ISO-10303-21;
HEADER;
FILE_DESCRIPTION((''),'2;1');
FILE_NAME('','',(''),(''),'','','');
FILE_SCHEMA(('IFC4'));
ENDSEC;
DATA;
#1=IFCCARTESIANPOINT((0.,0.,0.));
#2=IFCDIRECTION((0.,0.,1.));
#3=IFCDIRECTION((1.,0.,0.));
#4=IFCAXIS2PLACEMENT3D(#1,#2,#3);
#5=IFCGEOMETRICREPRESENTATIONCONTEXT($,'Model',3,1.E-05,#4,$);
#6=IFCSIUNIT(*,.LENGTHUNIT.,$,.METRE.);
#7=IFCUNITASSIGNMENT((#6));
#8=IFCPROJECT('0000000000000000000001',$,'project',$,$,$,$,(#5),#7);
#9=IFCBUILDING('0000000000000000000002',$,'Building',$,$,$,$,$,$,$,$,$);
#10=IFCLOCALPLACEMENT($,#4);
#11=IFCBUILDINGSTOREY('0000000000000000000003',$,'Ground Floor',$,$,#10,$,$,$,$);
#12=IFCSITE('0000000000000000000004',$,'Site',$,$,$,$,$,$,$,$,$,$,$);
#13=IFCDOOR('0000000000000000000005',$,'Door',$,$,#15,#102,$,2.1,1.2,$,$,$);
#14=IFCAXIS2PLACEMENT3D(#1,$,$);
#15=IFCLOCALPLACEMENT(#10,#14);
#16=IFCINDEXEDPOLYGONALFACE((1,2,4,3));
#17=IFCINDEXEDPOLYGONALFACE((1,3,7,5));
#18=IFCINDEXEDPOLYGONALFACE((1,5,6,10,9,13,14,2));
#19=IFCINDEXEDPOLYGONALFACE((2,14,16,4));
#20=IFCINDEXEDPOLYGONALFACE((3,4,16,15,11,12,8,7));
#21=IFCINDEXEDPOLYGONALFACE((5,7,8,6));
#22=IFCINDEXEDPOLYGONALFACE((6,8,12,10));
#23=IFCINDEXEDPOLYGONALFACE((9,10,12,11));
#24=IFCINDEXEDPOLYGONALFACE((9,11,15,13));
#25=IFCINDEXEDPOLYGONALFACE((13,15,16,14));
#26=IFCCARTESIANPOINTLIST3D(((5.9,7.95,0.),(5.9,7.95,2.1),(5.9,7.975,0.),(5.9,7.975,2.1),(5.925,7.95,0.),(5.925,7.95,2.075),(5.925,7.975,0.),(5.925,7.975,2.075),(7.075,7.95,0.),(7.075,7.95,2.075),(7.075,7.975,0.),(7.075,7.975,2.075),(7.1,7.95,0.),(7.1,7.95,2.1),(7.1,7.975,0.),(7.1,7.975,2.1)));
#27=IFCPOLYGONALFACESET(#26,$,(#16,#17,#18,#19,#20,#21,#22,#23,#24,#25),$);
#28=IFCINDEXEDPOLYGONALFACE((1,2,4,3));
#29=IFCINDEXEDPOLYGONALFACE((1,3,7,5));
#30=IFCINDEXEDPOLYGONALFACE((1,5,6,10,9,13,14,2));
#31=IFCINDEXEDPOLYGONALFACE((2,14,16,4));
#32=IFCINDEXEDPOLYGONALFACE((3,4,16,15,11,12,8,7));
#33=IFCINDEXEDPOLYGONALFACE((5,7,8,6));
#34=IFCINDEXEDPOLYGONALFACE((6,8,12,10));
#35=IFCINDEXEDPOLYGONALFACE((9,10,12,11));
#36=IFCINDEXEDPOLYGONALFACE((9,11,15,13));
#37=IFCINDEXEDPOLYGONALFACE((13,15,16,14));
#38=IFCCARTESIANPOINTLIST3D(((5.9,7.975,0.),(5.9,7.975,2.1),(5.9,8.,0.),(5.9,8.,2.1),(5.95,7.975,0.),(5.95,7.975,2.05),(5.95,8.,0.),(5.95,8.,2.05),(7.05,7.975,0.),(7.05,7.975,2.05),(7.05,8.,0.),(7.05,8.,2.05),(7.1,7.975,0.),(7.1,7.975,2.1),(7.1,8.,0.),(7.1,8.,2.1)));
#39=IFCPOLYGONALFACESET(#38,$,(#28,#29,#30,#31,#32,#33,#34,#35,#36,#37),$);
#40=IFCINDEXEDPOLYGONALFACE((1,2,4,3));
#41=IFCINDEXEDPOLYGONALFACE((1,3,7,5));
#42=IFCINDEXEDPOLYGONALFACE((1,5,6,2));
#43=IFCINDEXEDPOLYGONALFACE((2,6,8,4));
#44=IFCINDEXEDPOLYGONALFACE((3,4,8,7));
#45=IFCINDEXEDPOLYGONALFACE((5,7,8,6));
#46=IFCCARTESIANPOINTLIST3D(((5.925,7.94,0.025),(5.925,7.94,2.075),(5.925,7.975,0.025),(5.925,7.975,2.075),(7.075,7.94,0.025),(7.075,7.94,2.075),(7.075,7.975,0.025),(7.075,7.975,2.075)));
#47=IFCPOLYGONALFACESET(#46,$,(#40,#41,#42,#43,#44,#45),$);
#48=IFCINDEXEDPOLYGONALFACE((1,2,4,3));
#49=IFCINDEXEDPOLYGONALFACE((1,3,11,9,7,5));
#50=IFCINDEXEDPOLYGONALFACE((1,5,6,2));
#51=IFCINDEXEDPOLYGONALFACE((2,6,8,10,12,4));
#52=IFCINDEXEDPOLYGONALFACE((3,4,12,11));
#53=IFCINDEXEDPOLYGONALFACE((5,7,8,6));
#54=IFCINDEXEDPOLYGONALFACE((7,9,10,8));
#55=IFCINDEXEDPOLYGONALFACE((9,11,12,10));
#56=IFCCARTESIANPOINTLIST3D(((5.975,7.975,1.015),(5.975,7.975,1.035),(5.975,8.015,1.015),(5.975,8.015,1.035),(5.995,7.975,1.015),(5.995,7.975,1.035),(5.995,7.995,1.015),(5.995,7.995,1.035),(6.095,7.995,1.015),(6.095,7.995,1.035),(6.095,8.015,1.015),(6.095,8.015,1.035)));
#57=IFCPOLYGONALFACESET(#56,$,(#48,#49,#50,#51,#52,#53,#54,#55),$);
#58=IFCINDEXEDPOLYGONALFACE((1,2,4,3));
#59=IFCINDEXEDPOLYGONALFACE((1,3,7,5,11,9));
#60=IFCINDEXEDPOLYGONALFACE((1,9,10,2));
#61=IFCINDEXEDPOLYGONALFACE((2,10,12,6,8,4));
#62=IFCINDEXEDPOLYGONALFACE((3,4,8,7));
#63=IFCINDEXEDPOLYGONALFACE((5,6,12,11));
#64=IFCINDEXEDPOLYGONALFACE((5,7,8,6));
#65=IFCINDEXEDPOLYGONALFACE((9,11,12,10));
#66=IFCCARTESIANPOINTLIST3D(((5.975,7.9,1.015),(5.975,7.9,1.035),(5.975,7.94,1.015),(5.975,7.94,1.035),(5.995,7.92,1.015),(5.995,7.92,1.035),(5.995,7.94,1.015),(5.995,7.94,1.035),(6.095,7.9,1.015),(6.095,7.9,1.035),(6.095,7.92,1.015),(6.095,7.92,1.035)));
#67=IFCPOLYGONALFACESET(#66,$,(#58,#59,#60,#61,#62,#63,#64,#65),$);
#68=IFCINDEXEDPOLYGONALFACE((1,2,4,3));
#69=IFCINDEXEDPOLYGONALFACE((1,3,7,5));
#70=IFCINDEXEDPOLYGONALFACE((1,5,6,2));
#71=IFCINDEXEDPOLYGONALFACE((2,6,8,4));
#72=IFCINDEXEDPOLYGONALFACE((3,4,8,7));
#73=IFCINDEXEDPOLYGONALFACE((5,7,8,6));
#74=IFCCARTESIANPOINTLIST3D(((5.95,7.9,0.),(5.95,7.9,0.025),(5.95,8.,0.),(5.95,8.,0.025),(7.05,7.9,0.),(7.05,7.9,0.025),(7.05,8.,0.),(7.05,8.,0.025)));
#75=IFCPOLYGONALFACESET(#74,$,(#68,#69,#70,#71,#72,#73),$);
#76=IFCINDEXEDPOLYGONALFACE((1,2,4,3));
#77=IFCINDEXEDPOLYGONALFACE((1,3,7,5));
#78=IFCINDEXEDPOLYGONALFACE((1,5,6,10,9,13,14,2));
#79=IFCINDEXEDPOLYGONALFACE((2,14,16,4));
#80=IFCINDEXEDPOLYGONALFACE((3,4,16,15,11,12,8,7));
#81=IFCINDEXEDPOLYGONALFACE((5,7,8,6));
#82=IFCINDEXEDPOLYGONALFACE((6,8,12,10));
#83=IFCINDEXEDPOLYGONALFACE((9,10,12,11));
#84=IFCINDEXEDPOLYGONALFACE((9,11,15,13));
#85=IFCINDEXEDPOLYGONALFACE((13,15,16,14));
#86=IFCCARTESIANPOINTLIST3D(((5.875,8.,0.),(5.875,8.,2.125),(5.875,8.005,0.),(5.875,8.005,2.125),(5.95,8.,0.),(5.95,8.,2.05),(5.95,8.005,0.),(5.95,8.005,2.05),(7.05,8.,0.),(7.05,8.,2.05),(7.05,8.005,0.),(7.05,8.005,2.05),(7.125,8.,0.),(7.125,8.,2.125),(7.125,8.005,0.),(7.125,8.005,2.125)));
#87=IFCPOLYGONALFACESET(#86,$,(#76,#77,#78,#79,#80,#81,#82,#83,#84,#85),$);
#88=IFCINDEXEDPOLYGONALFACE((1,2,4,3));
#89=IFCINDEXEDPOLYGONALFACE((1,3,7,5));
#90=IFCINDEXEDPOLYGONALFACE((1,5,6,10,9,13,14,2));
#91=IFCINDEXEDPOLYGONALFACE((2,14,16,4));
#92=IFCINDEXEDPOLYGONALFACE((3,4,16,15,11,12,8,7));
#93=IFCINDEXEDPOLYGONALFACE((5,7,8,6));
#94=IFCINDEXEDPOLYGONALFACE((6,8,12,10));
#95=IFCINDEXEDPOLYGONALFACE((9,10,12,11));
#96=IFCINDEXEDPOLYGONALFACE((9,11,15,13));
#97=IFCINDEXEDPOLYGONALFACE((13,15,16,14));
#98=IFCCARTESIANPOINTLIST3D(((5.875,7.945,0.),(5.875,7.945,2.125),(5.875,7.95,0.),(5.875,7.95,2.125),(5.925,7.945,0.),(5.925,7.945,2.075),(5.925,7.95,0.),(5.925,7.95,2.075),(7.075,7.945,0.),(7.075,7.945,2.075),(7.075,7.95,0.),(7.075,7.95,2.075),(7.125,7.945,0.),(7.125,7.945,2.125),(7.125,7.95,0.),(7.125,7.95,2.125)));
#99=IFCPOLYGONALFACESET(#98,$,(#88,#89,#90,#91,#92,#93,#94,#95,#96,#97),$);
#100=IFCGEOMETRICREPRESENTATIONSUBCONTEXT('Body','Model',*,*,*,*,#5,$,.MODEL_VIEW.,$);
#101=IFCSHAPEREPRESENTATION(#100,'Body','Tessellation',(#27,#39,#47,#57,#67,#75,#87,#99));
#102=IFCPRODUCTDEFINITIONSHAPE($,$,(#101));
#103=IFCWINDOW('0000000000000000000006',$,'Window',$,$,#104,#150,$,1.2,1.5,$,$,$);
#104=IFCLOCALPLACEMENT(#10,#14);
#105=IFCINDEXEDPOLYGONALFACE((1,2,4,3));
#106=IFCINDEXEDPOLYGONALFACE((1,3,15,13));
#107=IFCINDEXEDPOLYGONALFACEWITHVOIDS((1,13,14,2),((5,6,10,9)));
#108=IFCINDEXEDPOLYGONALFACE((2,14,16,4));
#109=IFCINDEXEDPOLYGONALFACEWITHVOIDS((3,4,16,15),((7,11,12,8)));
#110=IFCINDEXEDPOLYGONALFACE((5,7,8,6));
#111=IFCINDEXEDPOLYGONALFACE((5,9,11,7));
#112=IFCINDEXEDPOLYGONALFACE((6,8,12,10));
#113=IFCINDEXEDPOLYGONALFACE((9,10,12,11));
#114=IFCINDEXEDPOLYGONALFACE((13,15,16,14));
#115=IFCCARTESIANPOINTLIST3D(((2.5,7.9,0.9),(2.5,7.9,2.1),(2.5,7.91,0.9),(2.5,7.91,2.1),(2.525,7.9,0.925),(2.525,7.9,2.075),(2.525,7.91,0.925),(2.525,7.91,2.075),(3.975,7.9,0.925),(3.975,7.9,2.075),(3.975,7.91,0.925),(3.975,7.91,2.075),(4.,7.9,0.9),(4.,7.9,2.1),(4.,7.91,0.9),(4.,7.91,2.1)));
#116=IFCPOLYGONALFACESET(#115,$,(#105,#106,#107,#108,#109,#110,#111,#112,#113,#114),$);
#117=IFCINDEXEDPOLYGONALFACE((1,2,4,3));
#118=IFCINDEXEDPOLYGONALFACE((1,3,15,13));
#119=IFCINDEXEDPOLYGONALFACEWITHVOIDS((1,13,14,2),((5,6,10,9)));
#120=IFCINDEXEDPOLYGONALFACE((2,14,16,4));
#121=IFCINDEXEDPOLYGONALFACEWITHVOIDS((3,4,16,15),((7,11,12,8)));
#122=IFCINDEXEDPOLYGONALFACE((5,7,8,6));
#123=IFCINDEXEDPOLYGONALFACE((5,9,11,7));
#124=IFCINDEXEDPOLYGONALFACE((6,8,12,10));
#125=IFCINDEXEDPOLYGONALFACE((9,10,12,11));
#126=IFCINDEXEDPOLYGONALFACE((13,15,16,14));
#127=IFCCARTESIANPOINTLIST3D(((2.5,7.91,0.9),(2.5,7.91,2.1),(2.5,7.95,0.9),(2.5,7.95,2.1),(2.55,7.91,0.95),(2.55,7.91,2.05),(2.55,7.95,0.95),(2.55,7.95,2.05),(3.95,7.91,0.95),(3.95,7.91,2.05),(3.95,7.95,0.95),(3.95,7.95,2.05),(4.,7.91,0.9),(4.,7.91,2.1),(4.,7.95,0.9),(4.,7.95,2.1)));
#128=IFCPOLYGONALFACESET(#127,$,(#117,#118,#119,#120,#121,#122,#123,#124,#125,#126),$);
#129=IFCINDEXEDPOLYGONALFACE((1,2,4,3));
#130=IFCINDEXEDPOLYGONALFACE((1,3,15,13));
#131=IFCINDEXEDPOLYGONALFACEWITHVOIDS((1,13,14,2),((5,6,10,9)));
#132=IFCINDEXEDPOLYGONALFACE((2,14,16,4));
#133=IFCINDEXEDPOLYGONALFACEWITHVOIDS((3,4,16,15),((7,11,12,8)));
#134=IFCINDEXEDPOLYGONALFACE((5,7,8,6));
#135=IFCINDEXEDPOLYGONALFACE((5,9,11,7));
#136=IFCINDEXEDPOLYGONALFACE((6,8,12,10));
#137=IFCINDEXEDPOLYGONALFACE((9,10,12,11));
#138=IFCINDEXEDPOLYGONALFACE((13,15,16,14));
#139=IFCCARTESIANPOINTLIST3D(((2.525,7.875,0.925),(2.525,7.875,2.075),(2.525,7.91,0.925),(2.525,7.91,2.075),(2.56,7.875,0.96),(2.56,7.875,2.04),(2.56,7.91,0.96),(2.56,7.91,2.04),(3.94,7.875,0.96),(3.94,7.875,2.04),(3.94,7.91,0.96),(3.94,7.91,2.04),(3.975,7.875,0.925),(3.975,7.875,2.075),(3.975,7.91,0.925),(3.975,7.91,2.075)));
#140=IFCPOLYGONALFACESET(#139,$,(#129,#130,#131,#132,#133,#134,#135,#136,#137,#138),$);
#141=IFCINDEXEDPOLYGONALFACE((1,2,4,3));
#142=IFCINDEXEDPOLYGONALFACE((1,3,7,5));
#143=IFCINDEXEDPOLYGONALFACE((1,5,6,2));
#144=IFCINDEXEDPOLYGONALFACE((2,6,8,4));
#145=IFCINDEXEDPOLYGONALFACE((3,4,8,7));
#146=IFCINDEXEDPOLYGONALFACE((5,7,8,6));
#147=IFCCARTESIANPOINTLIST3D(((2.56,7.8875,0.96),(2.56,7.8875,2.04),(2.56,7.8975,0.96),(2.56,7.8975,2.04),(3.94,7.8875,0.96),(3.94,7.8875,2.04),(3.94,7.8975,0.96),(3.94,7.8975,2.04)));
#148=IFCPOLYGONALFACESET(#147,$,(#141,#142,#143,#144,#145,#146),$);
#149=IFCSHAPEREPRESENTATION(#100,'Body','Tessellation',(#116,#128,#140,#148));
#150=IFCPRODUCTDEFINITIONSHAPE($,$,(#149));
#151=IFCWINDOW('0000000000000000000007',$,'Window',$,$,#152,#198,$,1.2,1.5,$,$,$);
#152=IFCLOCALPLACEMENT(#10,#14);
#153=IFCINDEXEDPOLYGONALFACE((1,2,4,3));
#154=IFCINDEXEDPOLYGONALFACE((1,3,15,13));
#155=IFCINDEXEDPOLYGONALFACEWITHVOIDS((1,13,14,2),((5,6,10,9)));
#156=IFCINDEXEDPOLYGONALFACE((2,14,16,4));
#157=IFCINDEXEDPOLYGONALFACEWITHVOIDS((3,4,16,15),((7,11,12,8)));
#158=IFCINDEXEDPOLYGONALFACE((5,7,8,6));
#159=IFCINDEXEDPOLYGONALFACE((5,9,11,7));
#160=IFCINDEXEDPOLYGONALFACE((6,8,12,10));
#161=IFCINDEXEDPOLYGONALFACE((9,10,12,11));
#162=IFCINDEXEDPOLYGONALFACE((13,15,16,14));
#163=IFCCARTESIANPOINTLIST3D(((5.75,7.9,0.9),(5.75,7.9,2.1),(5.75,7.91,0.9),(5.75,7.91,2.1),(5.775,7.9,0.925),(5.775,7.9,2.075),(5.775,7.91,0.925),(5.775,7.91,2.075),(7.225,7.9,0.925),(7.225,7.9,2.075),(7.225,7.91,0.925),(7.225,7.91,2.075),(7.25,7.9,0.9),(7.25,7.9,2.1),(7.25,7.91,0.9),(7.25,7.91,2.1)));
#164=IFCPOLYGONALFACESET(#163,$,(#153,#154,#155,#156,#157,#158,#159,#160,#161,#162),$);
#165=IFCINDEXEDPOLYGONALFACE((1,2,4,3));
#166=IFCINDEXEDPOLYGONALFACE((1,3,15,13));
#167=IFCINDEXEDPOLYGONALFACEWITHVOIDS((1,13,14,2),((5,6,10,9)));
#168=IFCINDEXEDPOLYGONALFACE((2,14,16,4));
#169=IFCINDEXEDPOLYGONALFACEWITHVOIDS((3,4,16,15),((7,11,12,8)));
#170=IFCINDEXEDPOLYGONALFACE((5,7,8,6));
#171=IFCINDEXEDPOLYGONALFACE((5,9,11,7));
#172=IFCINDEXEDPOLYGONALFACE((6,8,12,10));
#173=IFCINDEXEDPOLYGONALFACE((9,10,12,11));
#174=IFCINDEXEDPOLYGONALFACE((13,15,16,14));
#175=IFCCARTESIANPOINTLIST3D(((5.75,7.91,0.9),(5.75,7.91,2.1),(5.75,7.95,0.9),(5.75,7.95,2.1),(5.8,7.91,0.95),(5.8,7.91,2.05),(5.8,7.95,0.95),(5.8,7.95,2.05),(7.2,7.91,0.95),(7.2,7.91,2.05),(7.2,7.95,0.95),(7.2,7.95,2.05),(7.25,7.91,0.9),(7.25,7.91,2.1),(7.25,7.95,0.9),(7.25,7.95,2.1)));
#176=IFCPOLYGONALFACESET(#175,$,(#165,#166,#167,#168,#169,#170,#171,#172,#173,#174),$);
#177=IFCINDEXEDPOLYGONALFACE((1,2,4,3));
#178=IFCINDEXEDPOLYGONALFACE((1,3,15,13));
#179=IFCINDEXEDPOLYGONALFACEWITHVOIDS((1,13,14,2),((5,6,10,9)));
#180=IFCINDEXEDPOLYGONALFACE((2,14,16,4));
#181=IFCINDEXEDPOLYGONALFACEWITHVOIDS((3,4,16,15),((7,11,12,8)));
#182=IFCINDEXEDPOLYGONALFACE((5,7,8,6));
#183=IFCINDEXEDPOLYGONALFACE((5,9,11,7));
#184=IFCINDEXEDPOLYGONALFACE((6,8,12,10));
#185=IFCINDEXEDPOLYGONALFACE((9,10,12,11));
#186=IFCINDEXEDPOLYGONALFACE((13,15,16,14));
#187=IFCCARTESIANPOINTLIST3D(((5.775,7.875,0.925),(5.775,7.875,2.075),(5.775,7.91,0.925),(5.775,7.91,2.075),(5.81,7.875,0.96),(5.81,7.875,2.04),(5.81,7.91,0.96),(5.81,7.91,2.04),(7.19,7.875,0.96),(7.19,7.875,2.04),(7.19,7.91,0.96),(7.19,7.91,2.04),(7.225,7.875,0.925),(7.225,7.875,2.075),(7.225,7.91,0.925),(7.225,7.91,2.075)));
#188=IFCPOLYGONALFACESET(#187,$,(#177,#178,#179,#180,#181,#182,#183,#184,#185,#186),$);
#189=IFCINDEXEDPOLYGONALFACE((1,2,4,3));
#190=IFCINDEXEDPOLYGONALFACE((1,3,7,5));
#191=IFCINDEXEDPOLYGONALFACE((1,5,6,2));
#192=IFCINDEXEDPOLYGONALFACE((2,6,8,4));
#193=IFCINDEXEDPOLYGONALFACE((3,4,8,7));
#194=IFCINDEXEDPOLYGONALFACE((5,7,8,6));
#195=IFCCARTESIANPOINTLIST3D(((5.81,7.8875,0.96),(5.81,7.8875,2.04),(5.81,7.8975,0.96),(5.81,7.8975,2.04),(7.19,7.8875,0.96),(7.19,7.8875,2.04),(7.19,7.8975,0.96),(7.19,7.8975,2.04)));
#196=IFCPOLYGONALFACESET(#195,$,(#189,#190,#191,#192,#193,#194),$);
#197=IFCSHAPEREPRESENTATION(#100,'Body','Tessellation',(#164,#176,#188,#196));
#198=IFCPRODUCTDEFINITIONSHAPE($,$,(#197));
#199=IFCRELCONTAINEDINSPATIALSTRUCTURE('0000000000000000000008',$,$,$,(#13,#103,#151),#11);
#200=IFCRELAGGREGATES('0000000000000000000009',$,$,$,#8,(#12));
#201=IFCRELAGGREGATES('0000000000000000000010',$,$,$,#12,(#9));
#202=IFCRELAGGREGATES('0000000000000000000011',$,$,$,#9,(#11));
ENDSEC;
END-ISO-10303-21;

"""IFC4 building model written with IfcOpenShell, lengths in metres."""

from ifc_helpers import new_model, si_unit, frame, origin_with_axes, place, context, subcontext, project, spatial, line, indexed_curve, outline, extrude, element, save


model = new_model("IFC4")

# Units and contexts
model_context = context("Model", 3, precision=1e-05, world=origin_with_axes())
body_context = subcontext(model_context, "Body", "Model", "MODEL_VIEW")
ifc_project = project(units=[si_unit("LENGTHUNIT", "METRE")], contexts=[model_context])

# Site, building, storey
site = spatial("IfcSite", under=ifc_project, Name="Site")
building = spatial("IfcBuilding", under=site, Name="Building")
storey_placement = place(None, origin_with_axes())
storey = spatial("IfcBuildingStorey", under=building, at=storey_placement, Name="Ground Floor")

# Door
door_1_placement = place(storey_placement, frame((7.1, 8.0, 0.0), z_axis=(0.0, 0.0, 1.0), x_axis=(-1.0, 0.0, 0.0)))
element("IfcDoor", 1, at=door_1_placement, inside=storey, Name="Door", OverallHeight=2.1, OverallWidth=1.2, context=body_context, shape_type="SweptSolid", body=[
    extrude(outline(indexed_curve([(0.0, 0.0), (0.0, 2.1), (1.2, 2.1), (1.2, 0.0), (1.175, 0.0), (1.175, 2.075), (0.025, 2.075), (0.025, 0.0)], segments=[line(1, 2, 3, 4, 5, 6, 7, 8, 1)])), frame((0.0, 0.025, 0.0), z_axis=(0.0, -1.0, 0.0), x_axis=(1.0, 0.0, 0.0)), (0.0, 0.0, -1.0), 0.025),
    extrude(outline(indexed_curve([(0.0, 0.0), (0.0, 2.1), (1.2, 2.1), (1.2, 0.0), (1.15, 0.0), (1.15, 2.05), (0.05, 2.05), (0.05, 0.0)], segments=[line(1, 2, 3, 4, 5, 6, 7, 8, 1)])), frame((0.0, 0.0, 0.0), z_axis=(0.0, -1.0, 0.0), x_axis=(1.0, 0.0, 0.0)), (0.0, 0.0, -1.0), 0.025),
    extrude(outline(indexed_curve([(0.0, 0.0), (1.15, 0.0), (1.15, 0.035), (0.0, 0.035)], segments=[line(1, 2, 3, 4, 1)])), frame((0.025, 0.025, 0.025), z_axis=(0.0, 0.0, 1.0), x_axis=(1.0, 0.0, 0.0)), (0.0, 0.0, 1.0), 2.05),
    extrude(outline(indexed_curve([(0.0, 0.0), (0.0, -0.04), (-0.12, -0.04), (-0.12, -0.02), (-0.02, -0.02), (-0.02, 0.0)], segments=[line(1, 2, 3, 4, 5, 6, 1)])), frame((1.125, 0.025, 1.015), z_axis=(0.0, 0.0, 1.0), x_axis=(1.0, 0.0, 0.0)), (0.0, 0.0, 1.0), 0.02),
    extrude(outline(indexed_curve([(0.0, 0.0), (0.0, 0.04), (-0.12, 0.04), (-0.12, 0.02), (-0.02, 0.02), (-0.02, 0.0)], segments=[line(1, 2, 3, 4, 5, 6, 1)])), frame((1.125, 0.06, 1.015), z_axis=(0.0, 0.0, 1.0), x_axis=(1.0, 0.0, 0.0)), (0.0, 0.0, 1.0), 0.02),
    extrude(outline(indexed_curve([(0.0, 0.0), (1.1, 0.0), (1.1, 0.1), (0.0, 0.1)], segments=[line(1, 2, 3, 4, 1)])), frame((0.05, 0.0, 0.0), z_axis=(0.0, 0.0, 1.0), x_axis=(1.0, 0.0, 0.0)), (0.0, 0.0, 1.0), 0.025),
    extrude(outline(indexed_curve([(0.0, 0.0), (0.0, 2.125), (1.25, 2.125), (1.25, 0.0), (1.175, 0.0), (1.175, 2.05), (0.075, 2.05), (0.075, 0.0)], segments=[line(1, 2, 3, 4, 5, 6, 7, 8, 1)])), frame((-0.025, -0.005, 0.0), z_axis=(0.0, -1.0, 0.0), x_axis=(1.0, 0.0, 0.0)), (0.0, 0.0, -1.0), 0.005),
    extrude(outline(indexed_curve([(0.0, 0.0), (0.0, 2.125), (1.25, 2.125), (1.25, 0.0), (1.2, 0.0), (1.2, 2.075), (0.05, 2.075), (0.05, 0.0)], segments=[line(1, 2, 3, 4, 5, 6, 7, 8, 1)])), frame((-0.025, 0.05, 0.0), z_axis=(0.0, -1.0, 0.0), x_axis=(1.0, 0.0, 0.0)), (0.0, 0.0, -1.0), 0.005),
])

# Windows
for number, where, z_axis, x_axis, name in (
    (2, (4.0, 8.0, 0.9), (0.0, 0.0, 1.0), (-1.0, 0.0, 0.0), "Window"),
    (3, (7.25, 8.0, 0.9), (0.0, 0.0, 1.0), (-1.0, 0.0, 0.0), "Window"),
):
    element("IfcWindow", number, at=place(storey_placement, frame(where, z_axis=z_axis, x_axis=x_axis)), inside=storey, Name=name, OverallHeight=1.2, OverallWidth=1.5, context=body_context, shape_type="SweptSolid", body=[
        extrude(outline(indexed_curve([(0.0, 0.0), (1.5, 0.0), (1.5, 1.2), (0.0, 1.2)], segments=[line(1, 2, 3, 4, 1)]), holes=[indexed_curve([(0.025, 0.025), (1.475, 0.025), (1.475, 1.175), (0.025, 1.175)], segments=[line(1, 2, 3, 4, 1)])]), frame((0.0, 0.09, 0.0), z_axis=(0.0, -1.0, 0.0), x_axis=(1.0, 0.0, 0.0)), (0.0, 0.0, -1.0), 0.01),
        extrude(outline(indexed_curve([(0.0, 0.0), (1.5, 0.0), (1.5, 1.2), (0.0, 1.2)], segments=[line(1, 2, 3, 4, 1)]), holes=[indexed_curve([(0.05, 0.05), (1.45, 0.05), (1.45, 1.15), (0.05, 1.15)], segments=[line(1, 2, 3, 4, 1)])]), frame((0.0, 0.05, 0.0), z_axis=(0.0, -1.0, 0.0), x_axis=(1.0, 0.0, 0.0)), (0.0, 0.0, -1.0), 0.04),
        extrude(outline(indexed_curve([(0.0, 0.0), (1.45, 0.0), (1.45, 1.15), (0.0, 1.15)], segments=[line(1, 2, 3, 4, 1)]), holes=[indexed_curve([(0.035, 0.035), (1.415, 0.035), (1.415, 1.115), (0.035, 1.115)], segments=[line(1, 2, 3, 4, 1)])]), frame((0.025, 0.09, 0.025), z_axis=(0.0, -1.0, 0.0), x_axis=(1.0, 0.0, 0.0)), (0.0, 0.0, -1.0), 0.035),
        extrude(outline(indexed_curve([(0.035, 0.035), (1.415, 0.035), (1.415, 1.115), (0.035, 1.115)], segments=[line(1, 2, 3, 4, 1)])), frame((0.025, 0.1025, 0.025), z_axis=(0.0, -1.0, 0.0), x_axis=(1.0, 0.0, 0.0)), (0.0, 0.0, -1.0), 0.01),
    ])

save(model, "model.ifc")
